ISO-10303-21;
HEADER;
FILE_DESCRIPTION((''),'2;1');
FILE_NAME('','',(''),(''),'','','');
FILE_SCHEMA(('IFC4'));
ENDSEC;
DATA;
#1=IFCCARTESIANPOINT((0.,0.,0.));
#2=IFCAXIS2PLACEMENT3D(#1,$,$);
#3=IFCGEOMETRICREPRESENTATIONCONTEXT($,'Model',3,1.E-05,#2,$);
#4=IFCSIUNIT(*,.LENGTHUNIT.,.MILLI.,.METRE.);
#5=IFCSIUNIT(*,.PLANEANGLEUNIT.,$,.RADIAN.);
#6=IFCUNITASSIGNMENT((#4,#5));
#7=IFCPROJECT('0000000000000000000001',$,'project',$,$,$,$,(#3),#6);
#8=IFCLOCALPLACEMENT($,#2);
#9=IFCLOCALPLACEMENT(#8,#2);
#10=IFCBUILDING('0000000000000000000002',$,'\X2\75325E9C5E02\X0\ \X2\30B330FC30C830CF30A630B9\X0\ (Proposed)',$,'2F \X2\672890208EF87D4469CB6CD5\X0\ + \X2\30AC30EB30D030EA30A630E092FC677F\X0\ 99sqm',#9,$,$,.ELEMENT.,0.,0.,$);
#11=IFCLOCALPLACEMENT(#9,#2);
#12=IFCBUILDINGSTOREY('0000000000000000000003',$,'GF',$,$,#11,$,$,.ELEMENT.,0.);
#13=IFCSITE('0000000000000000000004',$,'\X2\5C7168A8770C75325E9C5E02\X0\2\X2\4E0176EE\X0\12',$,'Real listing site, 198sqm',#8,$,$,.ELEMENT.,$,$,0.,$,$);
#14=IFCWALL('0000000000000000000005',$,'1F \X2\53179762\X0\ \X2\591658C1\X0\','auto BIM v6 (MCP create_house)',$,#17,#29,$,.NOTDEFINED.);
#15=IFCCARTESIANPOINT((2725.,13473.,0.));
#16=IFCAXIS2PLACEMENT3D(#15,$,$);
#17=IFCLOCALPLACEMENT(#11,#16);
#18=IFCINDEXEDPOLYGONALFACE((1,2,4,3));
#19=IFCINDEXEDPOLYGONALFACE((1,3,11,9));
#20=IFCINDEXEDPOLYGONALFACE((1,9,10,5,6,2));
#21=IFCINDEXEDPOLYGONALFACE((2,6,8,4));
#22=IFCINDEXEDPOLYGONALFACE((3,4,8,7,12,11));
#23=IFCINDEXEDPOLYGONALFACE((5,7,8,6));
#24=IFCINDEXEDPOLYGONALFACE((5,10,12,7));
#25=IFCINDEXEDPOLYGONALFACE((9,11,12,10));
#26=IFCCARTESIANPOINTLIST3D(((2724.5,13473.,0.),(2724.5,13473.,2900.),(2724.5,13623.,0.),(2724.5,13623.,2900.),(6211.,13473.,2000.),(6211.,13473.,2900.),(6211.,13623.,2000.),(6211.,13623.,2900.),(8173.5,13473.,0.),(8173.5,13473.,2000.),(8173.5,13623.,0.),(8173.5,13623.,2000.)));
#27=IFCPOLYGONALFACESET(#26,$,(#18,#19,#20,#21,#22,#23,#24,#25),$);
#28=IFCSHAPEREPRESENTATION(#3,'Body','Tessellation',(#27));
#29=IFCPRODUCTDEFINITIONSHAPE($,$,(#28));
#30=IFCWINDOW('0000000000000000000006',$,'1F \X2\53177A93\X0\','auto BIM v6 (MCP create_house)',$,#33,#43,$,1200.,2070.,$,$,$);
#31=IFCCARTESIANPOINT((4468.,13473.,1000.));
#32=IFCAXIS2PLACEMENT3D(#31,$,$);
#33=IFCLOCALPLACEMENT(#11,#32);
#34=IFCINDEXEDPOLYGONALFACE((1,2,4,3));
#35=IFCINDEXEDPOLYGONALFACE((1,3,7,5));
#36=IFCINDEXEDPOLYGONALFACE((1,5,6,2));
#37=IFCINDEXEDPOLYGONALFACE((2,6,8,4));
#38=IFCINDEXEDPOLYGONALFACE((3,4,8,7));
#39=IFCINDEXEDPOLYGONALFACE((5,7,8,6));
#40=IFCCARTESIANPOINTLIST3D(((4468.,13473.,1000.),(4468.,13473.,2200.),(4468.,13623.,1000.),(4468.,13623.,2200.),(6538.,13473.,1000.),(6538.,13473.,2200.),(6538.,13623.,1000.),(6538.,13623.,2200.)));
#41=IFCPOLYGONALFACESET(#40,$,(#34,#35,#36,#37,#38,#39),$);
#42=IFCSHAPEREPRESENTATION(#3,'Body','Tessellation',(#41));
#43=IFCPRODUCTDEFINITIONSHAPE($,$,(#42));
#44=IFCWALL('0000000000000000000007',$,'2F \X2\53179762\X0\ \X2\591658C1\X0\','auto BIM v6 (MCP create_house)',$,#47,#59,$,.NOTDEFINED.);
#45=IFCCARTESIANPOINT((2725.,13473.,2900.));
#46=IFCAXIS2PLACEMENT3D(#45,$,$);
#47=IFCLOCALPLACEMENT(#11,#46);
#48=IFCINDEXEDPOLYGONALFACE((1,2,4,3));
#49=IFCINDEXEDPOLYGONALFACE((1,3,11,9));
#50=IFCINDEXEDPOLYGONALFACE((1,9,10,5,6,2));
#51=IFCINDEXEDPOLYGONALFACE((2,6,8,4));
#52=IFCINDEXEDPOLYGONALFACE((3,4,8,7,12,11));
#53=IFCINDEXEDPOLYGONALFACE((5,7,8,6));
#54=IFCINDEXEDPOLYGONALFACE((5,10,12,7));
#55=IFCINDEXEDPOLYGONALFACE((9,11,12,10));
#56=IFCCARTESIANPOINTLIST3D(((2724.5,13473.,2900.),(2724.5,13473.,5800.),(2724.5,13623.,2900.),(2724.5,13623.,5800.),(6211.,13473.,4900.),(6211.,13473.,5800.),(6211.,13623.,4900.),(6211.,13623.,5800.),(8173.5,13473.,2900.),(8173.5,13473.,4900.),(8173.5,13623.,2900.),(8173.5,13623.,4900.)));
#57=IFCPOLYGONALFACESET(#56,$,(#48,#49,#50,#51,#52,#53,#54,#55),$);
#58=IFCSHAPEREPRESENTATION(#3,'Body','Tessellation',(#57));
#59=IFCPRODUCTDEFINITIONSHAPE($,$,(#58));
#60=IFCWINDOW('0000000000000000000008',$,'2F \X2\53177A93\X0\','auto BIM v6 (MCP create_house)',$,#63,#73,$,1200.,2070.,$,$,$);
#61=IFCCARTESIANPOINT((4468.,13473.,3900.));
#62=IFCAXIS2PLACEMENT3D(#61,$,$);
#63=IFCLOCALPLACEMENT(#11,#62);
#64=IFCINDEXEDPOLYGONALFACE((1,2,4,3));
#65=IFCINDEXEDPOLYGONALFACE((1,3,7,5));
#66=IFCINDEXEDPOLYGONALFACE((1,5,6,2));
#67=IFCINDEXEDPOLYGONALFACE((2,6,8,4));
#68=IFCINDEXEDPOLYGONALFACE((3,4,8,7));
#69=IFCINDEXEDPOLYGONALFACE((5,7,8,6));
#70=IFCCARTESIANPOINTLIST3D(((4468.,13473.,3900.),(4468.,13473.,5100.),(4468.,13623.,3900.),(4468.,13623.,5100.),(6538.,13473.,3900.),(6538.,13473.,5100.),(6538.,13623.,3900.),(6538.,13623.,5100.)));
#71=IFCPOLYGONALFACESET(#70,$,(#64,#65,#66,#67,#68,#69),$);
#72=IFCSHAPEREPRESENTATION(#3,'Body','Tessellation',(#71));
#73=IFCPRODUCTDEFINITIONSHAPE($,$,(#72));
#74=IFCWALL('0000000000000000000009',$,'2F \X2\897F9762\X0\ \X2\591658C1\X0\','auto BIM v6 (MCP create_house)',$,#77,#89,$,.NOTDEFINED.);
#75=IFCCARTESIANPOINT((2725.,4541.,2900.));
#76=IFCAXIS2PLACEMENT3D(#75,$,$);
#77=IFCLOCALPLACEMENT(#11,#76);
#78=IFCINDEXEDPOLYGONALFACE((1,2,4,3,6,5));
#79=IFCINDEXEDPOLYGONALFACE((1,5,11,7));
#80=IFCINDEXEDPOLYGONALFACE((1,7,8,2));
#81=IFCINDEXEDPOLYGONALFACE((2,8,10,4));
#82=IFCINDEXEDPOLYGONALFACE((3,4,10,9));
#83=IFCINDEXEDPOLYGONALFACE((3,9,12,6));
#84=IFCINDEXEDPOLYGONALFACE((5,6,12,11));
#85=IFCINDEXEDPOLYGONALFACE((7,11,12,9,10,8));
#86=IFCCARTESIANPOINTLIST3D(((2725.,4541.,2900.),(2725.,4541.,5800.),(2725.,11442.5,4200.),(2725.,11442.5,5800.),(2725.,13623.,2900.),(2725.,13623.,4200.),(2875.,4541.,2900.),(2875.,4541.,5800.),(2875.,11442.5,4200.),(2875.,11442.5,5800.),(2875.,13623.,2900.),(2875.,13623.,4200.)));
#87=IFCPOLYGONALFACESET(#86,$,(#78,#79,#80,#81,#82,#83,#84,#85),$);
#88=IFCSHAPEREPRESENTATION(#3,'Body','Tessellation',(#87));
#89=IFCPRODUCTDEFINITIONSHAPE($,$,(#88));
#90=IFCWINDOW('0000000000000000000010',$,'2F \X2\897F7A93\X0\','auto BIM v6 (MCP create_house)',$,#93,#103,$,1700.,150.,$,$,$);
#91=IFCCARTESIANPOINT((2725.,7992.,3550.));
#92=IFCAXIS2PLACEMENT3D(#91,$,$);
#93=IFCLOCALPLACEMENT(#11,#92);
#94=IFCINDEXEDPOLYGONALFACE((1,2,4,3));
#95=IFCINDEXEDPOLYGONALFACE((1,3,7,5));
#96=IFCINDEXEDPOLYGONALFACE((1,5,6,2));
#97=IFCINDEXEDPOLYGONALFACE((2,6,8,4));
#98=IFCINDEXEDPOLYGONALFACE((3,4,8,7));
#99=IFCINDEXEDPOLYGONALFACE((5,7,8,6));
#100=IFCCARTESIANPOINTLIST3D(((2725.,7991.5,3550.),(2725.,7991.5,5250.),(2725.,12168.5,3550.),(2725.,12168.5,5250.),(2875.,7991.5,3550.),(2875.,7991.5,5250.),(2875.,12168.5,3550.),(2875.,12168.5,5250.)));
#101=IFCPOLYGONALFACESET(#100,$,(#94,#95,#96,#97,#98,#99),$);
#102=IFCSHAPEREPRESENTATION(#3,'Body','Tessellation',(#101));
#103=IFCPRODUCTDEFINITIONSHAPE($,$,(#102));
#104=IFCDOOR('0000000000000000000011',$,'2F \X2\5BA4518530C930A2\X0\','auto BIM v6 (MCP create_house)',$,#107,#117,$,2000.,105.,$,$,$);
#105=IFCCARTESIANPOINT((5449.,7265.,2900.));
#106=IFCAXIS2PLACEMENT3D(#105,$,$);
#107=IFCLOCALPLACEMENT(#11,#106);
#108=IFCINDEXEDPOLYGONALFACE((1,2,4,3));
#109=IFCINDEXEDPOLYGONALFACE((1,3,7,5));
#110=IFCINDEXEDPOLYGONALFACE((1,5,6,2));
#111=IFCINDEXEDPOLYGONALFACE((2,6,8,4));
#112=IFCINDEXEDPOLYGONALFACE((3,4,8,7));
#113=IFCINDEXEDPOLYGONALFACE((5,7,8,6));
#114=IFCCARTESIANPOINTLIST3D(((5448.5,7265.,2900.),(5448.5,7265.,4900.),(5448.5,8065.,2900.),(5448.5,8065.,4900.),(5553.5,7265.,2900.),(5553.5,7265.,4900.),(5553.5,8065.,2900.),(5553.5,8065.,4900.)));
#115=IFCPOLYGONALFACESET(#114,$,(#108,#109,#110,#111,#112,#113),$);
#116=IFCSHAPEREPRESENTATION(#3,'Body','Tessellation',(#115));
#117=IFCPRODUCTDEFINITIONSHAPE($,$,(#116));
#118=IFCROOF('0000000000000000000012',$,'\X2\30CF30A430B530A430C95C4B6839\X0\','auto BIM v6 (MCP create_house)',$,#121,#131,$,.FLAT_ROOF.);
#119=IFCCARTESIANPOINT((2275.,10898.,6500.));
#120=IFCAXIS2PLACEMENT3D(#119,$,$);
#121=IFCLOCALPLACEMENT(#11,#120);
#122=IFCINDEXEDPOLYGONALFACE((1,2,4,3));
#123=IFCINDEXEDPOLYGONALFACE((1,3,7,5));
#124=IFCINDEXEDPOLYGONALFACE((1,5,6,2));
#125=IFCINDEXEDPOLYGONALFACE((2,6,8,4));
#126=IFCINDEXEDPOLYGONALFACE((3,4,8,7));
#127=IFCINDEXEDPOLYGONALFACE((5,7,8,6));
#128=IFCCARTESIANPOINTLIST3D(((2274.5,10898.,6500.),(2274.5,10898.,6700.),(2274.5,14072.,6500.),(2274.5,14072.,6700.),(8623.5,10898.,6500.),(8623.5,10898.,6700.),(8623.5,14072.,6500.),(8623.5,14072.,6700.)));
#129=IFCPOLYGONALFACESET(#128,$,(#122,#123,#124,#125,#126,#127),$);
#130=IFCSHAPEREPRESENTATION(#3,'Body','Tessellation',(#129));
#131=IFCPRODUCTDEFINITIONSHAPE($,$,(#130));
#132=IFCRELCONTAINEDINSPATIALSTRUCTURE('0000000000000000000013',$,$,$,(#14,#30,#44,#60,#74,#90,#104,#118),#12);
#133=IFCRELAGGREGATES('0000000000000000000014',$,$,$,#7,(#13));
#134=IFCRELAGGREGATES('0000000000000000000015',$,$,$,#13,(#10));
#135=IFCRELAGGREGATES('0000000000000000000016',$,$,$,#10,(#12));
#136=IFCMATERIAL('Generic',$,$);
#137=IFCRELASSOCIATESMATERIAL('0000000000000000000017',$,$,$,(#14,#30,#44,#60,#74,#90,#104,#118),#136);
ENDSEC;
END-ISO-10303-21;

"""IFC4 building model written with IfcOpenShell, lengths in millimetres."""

from ifc_helpers import new_model, si_unit, frame, frame_2d, origin, place, context, project, spatial, rectangle, extrude, material, element, fill, save


model = new_model("IFC4")

# Units and contexts
model_context = context("Model", 3, precision=1e-05, world=origin())
ifc_project = project(units=[si_unit("LENGTHUNIT", "METRE", prefix="MILLI"), si_unit("PLANEANGLEUNIT", "RADIAN")], contexts=[model_context])

# Site, building, storey
site_placement = place(None, origin())
site = spatial("IfcSite", under=ifc_project, at=site_placement, Name="山梨県甲府市2丁目12", ObjectType="Real listing site, 198sqm", CompositionType="ELEMENT", RefElevation=0.0)
building_placement = place(site_placement, origin())
building = spatial("IfcBuilding", under=site, at=building_placement, Name="甲府市 コートハウス (Proposed)", ObjectType="2F 木造軸組構法 + ガルバリウム鋼板 99sqm", CompositionType="ELEMENT", ElevationOfRefHeight=0.0, ElevationOfTerrain=0.0)
storey_placement = place(building_placement, origin())
storey = spatial("IfcBuildingStorey", under=building, at=storey_placement, Name="GF", CompositionType="ELEMENT", Elevation=0.0)

# Wall, opening, window
ifc_material = material(Name="Generic")
wall_1_placement = place(storey_placement, frame((2725.0, 13473.0, 0.0)))
wall_1 = element("IfcWall", 1, at=wall_1_placement, inside=storey, material=ifc_material, Name="1F 北面 外壁", Description="auto BIM v6 (MCP create_house)", PredefinedType="NOTDEFINED", context=model_context, shape_type="SweptSolid", body=[
    extrude(rectangle(XDim=5449.0, YDim=150.0, at=frame_2d((2724.0, 75.0))), frame((2725.0, 13473.0, 0.0)), (0.0, 0.0, 1.0), 2900.0),
])
opening_1_placement = place(storey_placement, frame((4468.0, 13473.0, 1000.0)))
opening_1 = element("IfcOpeningElement", 2, at=opening_1_placement, cuts=wall_1, PredefinedType="NOTDEFINED", context=model_context, shape_type="SweptSolid", body=[
    extrude(rectangle(XDim=2070.0, YDim=150.0, at=frame_2d((1035.0, 75.0))), frame((4468.0, 13473.0, 1000.0)), (0.0, 0.0, 1.0), 1200.0),
])
window_1_placement = place(storey_placement, frame((4468.0, 13473.0, 1000.0)))
window_1 = element("IfcWindow", 3, at=window_1_placement, inside=storey, material=ifc_material, Name="1F 北窓", Description="auto BIM v6 (MCP create_house)", OverallHeight=1200.0, OverallWidth=2070.0, context=model_context, shape_type="SweptSolid", body=[
    extrude(rectangle(XDim=2070.0, YDim=150.0, at=frame_2d((1035.0, 75.0))), frame((4468.0, 13473.0, 1000.0)), (0.0, 0.0, 1.0), 1200.0),
])
fill(opening_1, window_1)

# Walls, openings, windows
wall_2_placement = place(storey_placement, frame((2725.0, 13473.0, 2900.0)))
wall_2 = element("IfcWall", 4, at=wall_2_placement, inside=storey, material=ifc_material, Name="2F 北面 外壁", Description="auto BIM v6 (MCP create_house)", PredefinedType="NOTDEFINED", context=model_context, shape_type="SweptSolid", body=[
    extrude(rectangle(XDim=5449.0, YDim=150.0, at=frame_2d((2724.0, 75.0))), frame((2725.0, 13473.0, 2900.0)), (0.0, 0.0, 1.0), 2900.0),
])
opening_2_placement = place(storey_placement, frame((4468.0, 13473.0, 3900.0)))
opening_2 = element("IfcOpeningElement", 5, at=opening_2_placement, cuts=wall_2, PredefinedType="NOTDEFINED", context=model_context, shape_type="SweptSolid", body=[
    extrude(rectangle(XDim=2070.0, YDim=150.0, at=frame_2d((1035.0, 75.0))), frame((4468.0, 13473.0, 3900.0)), (0.0, 0.0, 1.0), 1200.0),
])
window_2_placement = place(storey_placement, frame((4468.0, 13473.0, 3900.0)))
window_2 = element("IfcWindow", 6, at=window_2_placement, inside=storey, material=ifc_material, Name="2F 北窓", Description="auto BIM v6 (MCP create_house)", OverallHeight=1200.0, OverallWidth=2070.0, context=model_context, shape_type="SweptSolid", body=[
    extrude(rectangle(XDim=2070.0, YDim=150.0, at=frame_2d((1035.0, 75.0))), frame((4468.0, 13473.0, 3900.0)), (0.0, 0.0, 1.0), 1200.0),
])
fill(opening_2, window_2)
wall_3_placement = place(storey_placement, frame((2725.0, 4541.0, 2900.0)))
wall_3 = element("IfcWall", 7, at=wall_3_placement, inside=storey, material=ifc_material, Name="2F 西面 外壁", Description="auto BIM v6 (MCP create_house)", PredefinedType="NOTDEFINED", context=model_context, shape_type="SweptSolid", body=[
    extrude(rectangle(XDim=150.0, YDim=9082.0, at=frame_2d((75.0, 4541.0))), frame((2725.0, 4541.0, 2900.0)), (0.0, 0.0, 1.0), 2900.0),
])
opening_3_placement = place(storey_placement, frame((2725.0, 7992.0, 3550.0)))
opening_3 = element("IfcOpeningElement", 8, at=opening_3_placement, cuts=wall_3, PredefinedType="NOTDEFINED", context=model_context, shape_type="SweptSolid", body=[
    extrude(rectangle(XDim=150.0, YDim=4177.0, at=frame_2d((75.0, 2088.0))), frame((2725.0, 7992.0, 3550.0)), (0.0, 0.0, 1.0), 1700.0),
])
window_3_placement = place(storey_placement, frame((2725.0, 7992.0, 3550.0)))
window_3 = element("IfcWindow", 9, at=window_3_placement, inside=storey, material=ifc_material, Name="2F 西窓", Description="auto BIM v6 (MCP create_house)", OverallHeight=1700.0, OverallWidth=150.0, context=model_context, shape_type="SweptSolid", body=[
    extrude(rectangle(XDim=150.0, YDim=4177.0, at=frame_2d((75.0, 2088.0))), frame((2725.0, 7992.0, 3550.0)), (0.0, 0.0, 1.0), 1700.0),
])
fill(opening_3, window_3)

# Door
door_placement = place(storey_placement, frame((5449.0, 7265.0, 2900.0)))
element("IfcDoor", 10, at=door_placement, inside=storey, material=ifc_material, Name="2F 室内ドア", Description="auto BIM v6 (MCP create_house)", OverallHeight=2000.0, OverallWidth=105.0, context=model_context, shape_type="SweptSolid", body=[
    extrude(rectangle(XDim=105.0, YDim=800.0, at=frame_2d((52.0, 400.0))), frame((5449.0, 7265.0, 2900.0)), (0.0, 0.0, 1.0), 2000.0),
])

# Roof
roof_placement = place(storey_placement, frame((2275.0, 10898.0, 6500.0)))
element("IfcRoof", 11, at=roof_placement, inside=storey, material=ifc_material, Name="ハイサイド屋根", Description="auto BIM v6 (MCP create_house)", PredefinedType="FLAT_ROOF", context=model_context, shape_type="SweptSolid", body=[
    extrude(rectangle(XDim=6349.0, YDim=3174.0, at=frame_2d((3174.0, 1587.0))), frame((2275.0, 10898.0, 6500.0)), (0.0, 0.0, 1.0), 200.0),
])

save(model, "model.ifc")
